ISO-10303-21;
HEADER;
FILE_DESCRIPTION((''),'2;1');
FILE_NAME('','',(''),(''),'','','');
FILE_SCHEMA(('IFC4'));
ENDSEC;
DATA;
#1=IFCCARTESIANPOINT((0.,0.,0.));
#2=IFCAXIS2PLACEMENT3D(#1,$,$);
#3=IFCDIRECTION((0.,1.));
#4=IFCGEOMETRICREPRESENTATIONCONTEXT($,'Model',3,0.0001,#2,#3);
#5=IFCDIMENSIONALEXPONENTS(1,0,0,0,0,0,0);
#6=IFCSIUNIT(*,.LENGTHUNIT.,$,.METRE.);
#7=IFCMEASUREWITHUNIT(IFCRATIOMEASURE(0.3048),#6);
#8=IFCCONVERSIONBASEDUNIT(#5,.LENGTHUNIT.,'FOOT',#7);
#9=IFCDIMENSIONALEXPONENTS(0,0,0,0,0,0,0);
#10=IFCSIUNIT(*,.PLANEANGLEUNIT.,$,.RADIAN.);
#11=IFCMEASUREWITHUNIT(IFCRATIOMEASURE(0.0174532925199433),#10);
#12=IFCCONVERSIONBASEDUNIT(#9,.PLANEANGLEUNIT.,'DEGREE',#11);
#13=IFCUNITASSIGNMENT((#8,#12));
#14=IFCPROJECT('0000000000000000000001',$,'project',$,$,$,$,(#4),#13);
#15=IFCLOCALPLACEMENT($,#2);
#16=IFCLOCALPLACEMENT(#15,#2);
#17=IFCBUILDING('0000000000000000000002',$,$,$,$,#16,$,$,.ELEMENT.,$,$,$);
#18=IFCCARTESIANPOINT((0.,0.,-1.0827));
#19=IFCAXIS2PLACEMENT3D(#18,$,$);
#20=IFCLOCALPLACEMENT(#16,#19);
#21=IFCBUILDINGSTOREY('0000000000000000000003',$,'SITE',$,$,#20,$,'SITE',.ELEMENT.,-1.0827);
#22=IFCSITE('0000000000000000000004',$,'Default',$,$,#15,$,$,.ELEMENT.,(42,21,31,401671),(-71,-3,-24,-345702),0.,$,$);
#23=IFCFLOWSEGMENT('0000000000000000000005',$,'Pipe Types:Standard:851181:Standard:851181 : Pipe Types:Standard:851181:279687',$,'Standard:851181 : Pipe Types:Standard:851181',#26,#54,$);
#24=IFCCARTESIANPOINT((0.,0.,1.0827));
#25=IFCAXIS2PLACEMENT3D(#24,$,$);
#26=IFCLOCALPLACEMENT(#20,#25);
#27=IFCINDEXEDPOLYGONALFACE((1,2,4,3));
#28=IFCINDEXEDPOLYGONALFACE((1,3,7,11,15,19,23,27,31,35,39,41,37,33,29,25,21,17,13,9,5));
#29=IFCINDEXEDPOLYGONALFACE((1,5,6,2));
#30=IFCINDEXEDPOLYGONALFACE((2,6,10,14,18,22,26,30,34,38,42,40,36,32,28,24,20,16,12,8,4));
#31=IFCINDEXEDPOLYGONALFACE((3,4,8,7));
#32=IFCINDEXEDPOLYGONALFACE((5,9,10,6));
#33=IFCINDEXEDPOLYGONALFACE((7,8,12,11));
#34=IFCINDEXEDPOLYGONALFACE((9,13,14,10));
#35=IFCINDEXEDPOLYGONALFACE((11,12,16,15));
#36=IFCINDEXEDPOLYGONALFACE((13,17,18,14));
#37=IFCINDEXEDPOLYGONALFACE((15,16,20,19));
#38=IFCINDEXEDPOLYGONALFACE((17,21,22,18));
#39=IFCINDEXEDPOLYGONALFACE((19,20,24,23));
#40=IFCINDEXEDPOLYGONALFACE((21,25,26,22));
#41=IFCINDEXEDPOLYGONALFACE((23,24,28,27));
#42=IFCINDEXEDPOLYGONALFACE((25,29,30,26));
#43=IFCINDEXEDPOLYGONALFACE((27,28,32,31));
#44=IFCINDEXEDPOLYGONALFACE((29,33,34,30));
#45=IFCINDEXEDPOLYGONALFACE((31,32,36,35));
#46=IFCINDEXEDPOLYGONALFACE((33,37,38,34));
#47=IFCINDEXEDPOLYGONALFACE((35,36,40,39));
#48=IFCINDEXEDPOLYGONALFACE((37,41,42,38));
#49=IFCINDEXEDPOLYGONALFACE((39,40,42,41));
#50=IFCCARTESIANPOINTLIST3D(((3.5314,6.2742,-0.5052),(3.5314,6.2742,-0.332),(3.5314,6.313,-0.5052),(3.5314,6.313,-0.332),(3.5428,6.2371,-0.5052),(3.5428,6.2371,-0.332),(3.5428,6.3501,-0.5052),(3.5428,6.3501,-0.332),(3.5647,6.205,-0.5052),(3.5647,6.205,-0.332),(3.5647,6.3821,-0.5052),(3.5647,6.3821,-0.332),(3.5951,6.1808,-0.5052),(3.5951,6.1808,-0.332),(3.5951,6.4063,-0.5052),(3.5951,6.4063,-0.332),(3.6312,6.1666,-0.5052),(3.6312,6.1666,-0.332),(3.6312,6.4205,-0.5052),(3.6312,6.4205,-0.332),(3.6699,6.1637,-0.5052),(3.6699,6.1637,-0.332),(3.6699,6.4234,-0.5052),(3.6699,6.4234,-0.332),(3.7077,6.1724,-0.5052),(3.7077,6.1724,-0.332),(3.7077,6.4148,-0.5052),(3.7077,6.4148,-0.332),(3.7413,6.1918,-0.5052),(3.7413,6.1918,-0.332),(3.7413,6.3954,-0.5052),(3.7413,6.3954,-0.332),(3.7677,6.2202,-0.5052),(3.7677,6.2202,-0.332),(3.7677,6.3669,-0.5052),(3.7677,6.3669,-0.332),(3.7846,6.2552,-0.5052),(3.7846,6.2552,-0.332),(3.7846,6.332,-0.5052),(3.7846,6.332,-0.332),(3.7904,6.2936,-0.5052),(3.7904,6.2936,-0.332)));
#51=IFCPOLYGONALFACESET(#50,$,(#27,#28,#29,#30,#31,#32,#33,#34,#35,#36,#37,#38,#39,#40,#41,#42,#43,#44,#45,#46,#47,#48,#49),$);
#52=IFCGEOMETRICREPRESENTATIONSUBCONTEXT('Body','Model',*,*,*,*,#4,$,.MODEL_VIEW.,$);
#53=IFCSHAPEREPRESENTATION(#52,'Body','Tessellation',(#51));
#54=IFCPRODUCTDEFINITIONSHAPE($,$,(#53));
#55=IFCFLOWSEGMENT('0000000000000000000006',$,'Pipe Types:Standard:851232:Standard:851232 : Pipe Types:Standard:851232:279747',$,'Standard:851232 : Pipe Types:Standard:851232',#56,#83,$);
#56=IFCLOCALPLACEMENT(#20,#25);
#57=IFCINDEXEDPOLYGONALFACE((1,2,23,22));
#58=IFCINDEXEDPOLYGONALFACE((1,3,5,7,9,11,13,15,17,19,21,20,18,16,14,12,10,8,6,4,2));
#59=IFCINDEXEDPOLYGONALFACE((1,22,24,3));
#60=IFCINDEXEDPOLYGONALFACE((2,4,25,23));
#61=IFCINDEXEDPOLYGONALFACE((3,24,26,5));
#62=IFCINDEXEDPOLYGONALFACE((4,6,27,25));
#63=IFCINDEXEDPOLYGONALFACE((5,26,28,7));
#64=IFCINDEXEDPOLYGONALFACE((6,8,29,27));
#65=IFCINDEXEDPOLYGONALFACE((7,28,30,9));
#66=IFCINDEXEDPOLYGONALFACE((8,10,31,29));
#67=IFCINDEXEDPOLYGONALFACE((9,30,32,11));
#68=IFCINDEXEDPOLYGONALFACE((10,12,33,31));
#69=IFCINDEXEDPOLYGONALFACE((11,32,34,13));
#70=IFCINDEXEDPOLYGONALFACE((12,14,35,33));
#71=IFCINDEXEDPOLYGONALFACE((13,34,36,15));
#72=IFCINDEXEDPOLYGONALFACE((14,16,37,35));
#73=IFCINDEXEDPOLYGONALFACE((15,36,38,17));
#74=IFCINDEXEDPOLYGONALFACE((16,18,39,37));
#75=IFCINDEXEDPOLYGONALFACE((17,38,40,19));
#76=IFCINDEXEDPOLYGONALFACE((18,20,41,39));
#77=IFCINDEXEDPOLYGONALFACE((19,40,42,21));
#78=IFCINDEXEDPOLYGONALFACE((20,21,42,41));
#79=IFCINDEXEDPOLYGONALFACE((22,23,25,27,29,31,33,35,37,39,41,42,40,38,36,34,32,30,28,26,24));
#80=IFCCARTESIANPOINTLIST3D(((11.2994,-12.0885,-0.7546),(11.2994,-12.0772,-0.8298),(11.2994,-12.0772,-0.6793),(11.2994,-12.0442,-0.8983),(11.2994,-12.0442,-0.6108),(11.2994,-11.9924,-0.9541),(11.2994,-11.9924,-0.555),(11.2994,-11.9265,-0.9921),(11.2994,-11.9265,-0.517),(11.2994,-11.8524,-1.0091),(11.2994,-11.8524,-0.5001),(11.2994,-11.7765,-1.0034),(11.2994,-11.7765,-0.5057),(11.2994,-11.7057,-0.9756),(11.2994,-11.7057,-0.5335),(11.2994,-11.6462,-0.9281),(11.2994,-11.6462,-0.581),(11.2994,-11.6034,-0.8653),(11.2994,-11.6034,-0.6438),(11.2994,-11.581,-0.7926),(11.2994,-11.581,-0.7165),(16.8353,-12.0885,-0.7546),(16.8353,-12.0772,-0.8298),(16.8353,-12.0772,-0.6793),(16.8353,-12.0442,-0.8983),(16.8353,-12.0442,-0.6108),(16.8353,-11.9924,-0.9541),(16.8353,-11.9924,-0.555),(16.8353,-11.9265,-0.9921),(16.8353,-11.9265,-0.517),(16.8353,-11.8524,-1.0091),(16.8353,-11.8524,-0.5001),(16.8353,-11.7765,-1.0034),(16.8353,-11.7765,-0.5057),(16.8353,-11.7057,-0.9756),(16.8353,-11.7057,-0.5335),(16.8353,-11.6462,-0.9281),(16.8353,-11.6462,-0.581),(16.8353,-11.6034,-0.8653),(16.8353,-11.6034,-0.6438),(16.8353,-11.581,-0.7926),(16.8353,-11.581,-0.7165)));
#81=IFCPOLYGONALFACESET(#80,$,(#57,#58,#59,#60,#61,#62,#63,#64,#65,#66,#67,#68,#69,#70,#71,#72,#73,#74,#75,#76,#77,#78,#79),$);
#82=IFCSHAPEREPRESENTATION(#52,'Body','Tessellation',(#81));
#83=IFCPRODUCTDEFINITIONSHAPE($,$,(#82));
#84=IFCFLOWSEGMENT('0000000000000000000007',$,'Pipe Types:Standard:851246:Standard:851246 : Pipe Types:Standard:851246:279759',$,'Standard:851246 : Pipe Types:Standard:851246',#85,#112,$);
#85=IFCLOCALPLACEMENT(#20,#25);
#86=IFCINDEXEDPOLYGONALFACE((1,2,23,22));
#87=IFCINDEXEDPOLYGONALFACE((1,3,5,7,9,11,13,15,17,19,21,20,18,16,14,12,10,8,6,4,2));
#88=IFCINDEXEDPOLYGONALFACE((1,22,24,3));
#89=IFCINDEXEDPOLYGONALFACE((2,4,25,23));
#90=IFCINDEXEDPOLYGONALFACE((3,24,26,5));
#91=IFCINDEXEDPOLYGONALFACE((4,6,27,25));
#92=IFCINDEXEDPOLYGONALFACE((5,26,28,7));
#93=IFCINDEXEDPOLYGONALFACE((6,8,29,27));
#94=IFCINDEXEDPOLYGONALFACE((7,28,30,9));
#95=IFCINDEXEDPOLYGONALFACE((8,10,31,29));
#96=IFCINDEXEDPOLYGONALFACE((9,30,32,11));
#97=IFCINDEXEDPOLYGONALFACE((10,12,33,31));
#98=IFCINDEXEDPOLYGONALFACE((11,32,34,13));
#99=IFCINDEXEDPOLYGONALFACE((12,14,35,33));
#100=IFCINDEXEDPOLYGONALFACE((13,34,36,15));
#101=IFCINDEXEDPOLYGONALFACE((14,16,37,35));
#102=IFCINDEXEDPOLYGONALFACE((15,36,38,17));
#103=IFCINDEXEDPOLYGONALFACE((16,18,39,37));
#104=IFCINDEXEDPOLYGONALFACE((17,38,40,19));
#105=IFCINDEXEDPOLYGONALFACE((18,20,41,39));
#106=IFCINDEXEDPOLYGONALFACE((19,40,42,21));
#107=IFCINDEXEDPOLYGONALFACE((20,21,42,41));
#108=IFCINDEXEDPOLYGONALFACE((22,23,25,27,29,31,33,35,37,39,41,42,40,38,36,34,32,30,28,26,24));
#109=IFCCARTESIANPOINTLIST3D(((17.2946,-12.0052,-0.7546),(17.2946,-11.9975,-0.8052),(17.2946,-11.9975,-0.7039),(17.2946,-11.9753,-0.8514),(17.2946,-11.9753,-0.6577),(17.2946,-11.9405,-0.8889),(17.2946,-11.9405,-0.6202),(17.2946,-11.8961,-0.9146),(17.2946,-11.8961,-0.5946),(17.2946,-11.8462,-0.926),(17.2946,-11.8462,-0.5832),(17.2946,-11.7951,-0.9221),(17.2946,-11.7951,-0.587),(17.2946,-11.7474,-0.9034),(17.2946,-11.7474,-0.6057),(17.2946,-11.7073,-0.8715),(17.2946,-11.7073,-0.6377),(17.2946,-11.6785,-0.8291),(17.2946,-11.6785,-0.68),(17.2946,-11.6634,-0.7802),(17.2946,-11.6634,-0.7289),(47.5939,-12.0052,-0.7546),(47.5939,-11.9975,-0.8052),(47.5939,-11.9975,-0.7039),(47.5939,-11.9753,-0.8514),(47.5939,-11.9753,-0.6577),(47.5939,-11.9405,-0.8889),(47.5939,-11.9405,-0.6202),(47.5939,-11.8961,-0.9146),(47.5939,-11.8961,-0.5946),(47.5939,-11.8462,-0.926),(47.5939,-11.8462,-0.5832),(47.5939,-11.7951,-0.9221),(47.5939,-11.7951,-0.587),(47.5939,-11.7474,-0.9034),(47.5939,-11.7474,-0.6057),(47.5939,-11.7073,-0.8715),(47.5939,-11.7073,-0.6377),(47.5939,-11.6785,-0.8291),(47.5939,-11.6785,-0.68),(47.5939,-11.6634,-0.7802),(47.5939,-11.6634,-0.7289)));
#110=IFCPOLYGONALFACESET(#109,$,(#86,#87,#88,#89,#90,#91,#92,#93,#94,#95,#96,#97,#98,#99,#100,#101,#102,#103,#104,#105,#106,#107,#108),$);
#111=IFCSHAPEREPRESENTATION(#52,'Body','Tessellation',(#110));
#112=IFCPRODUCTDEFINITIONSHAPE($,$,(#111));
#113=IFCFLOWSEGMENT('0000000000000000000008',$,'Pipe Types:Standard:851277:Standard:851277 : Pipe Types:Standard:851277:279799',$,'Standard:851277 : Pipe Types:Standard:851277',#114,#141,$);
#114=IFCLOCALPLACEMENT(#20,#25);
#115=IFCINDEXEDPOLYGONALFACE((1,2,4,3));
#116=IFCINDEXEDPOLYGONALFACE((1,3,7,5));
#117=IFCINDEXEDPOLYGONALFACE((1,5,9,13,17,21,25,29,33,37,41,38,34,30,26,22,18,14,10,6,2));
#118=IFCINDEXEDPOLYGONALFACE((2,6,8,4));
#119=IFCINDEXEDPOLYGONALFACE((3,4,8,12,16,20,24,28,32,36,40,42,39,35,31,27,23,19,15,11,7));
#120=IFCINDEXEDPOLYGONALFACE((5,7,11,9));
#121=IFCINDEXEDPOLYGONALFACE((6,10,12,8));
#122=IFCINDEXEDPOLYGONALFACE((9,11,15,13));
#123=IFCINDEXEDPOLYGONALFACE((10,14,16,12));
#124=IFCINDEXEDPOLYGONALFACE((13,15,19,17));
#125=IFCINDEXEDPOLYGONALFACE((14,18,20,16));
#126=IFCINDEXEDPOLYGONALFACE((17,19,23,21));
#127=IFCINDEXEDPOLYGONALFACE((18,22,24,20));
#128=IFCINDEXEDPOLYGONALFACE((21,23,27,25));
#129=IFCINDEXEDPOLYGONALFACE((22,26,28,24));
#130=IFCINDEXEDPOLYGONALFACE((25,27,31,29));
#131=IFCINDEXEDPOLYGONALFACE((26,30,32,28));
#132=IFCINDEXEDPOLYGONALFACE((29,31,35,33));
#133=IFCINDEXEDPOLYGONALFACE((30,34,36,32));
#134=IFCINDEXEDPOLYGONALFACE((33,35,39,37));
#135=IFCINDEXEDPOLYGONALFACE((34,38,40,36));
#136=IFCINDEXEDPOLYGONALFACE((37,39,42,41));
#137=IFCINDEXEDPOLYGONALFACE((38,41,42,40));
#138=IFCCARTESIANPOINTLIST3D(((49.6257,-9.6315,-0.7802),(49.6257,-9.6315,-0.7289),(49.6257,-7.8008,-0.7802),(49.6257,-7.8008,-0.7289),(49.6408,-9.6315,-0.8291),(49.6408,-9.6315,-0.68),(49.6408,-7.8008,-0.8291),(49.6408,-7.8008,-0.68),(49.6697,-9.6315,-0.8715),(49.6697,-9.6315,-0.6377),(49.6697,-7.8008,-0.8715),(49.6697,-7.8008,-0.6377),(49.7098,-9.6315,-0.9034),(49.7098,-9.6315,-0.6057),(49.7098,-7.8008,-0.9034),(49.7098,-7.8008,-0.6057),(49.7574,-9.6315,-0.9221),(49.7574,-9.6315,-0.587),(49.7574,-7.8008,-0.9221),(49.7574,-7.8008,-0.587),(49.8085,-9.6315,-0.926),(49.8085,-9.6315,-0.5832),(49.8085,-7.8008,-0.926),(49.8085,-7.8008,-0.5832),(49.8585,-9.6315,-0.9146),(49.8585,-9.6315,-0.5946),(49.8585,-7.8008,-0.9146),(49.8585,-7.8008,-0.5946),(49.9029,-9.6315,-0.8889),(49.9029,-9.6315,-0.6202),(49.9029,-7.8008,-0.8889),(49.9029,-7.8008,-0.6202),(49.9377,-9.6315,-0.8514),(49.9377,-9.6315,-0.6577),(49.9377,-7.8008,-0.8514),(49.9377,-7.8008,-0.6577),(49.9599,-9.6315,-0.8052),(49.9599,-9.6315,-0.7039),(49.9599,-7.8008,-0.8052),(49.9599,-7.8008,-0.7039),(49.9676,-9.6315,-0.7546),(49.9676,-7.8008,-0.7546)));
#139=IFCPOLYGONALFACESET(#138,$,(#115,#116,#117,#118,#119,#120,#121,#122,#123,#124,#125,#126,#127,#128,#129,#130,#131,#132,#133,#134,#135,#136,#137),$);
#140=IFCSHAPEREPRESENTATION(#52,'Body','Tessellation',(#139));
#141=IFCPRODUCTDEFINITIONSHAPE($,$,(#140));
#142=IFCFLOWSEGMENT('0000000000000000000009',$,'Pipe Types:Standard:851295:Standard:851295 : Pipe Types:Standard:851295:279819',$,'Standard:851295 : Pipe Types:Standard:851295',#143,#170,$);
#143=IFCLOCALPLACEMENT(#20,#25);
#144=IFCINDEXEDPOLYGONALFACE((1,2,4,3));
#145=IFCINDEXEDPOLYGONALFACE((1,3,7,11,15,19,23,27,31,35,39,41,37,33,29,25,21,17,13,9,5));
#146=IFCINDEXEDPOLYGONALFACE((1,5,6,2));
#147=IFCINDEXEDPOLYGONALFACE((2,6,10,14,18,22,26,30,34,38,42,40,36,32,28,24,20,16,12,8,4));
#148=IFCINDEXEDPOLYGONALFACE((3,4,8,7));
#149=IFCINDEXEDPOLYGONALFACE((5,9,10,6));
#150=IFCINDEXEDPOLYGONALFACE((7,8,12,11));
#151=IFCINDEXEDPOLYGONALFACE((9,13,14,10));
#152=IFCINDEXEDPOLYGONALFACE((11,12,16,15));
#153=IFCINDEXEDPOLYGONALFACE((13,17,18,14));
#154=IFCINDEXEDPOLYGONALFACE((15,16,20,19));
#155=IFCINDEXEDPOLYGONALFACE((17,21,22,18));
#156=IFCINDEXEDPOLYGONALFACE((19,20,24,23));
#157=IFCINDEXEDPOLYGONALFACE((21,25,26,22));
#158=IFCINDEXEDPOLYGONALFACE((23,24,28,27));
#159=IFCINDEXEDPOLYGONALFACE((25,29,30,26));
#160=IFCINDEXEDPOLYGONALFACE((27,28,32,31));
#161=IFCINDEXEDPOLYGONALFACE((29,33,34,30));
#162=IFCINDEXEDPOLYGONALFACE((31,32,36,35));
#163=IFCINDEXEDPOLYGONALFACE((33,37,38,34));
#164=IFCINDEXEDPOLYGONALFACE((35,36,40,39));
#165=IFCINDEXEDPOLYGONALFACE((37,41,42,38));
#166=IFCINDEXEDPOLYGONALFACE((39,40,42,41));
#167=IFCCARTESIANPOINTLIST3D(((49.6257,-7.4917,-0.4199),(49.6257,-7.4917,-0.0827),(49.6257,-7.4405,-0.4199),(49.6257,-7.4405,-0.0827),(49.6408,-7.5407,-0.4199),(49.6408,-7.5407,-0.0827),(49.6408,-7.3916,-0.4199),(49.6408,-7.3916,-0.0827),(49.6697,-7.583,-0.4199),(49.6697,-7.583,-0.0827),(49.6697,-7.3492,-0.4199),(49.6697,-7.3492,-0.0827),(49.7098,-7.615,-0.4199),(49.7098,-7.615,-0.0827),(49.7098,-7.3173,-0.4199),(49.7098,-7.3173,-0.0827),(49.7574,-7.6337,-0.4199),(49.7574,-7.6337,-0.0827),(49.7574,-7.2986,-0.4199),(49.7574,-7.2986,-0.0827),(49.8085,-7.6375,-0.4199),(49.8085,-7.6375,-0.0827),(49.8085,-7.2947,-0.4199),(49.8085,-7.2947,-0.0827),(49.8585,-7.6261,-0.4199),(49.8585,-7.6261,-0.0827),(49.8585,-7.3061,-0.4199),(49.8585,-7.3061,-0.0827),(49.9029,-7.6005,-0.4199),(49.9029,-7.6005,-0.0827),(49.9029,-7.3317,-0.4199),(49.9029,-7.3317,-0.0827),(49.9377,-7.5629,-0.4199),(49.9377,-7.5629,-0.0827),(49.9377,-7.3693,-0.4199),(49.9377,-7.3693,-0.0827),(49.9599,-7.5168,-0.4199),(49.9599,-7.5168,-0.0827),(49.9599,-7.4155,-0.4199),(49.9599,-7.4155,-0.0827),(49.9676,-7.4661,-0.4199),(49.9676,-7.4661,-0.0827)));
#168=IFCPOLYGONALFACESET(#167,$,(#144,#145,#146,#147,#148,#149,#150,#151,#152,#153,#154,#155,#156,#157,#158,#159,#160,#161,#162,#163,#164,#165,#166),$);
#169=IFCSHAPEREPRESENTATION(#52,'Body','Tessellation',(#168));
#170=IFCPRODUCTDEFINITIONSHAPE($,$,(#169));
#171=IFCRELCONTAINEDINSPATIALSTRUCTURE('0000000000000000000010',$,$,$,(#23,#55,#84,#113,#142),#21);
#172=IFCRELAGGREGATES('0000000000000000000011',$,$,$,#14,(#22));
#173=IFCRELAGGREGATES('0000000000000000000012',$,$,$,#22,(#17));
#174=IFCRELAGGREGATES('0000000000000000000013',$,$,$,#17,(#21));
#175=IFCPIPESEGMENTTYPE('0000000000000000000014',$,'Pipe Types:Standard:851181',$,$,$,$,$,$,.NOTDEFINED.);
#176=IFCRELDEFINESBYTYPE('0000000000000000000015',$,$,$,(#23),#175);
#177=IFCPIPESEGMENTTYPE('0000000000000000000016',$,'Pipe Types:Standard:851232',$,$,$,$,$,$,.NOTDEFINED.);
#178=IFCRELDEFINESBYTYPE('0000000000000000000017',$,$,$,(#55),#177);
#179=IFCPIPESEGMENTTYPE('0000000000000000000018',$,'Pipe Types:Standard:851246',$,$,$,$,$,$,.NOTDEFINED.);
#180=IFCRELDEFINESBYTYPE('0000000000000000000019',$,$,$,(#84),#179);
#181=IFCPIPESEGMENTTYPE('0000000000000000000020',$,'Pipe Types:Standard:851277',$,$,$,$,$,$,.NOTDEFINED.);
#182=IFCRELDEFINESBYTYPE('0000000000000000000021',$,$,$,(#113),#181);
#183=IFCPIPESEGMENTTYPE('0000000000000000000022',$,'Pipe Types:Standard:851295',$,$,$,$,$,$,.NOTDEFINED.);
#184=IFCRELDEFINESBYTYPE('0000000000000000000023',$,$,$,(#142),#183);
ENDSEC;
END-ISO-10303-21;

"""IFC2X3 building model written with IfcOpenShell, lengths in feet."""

from ifc_helpers import new_model, entity, si_unit, converted_unit, direction, frame, frame_2d, origin, origin_2d_with_axis, place, context, subcontext, project, spatial, circle, extrude, source, transform, mapped, type_object, type_shapes, element, save


model = new_model("IFC2X3")

# Units and contexts
model_context = context("Model", 3, precision=0.0001, world=origin(), true_north=direction((0.0, 1.0)))
body_context = subcontext(model_context, "Body", "Model", "MODEL_VIEW")
ifc_project = project(units=[converted_unit("LENGTHUNIT", "FOOT", entity("IfcRatioMeasure", 0.3048), si_unit("LENGTHUNIT", "METRE"), dimensions=[1, 0, 0, 0, 0, 0, 0]), converted_unit("PLANEANGLEUNIT", "DEGREE", entity("IfcRatioMeasure", 0.0174532925199433), si_unit("PLANEANGLEUNIT", "RADIAN"), dimensions=[0, 0, 0, 0, 0, 0, 0])], contexts=[model_context])

# Site, building, storey
site_placement = place(None, origin())
site = spatial("IfcSite", under=ifc_project, at=site_placement, Name="Default", CompositionType="ELEMENT", RefLatitude=(42, 21, 31, 401671), RefLongitude=(-71, -3, -24, -345702), RefElevation=0.0)
building_placement = place(site_placement, origin())
building = spatial("IfcBuilding", under=site, at=building_placement, CompositionType="ELEMENT")
storey_placement = place(building_placement, frame((0.0, 0.0, -1.0827)))
storey = spatial("IfcBuildingStorey", under=building, at=storey_placement, Name="SITE", LongName="SITE", CompositionType="ELEMENT", Elevation=-1.0827)

# Flow segments
pipe_segment_type_1 = type_object("IfcPipeSegmentType", Name="Pipe Types:Standard:851181", PredefinedType="NOTDEFINED")
shared_shape_1 = source(origin(), body_context, "Body", "SweptSolid", [
    extrude(circle(Radius=0.1302, at=origin_2d_with_axis()), frame((3.6602, 6.2936, -0.5052)), (0.0, 0.0, 1.0), 0.1732),
])
type_shapes(pipe_segment_type_1, [shared_shape_1])
flow_segment_1_placement = place(storey_placement, frame((0.0, 0.0, 1.0827)))
element("IfcFlowSegment", 1, at=flow_segment_1_placement, inside=storey, type_object=pipe_segment_type_1, Name="Pipe Types:Standard:851181:Standard:851181 : Pipe Types:Standard:851181:279687", ObjectType="Standard:851181 : Pipe Types:Standard:851181", context=body_context, shape_type="MappedRepresentation", body=[
    mapped(shared_shape_1, transform((0.0, 0.0, 0.0), scale=1.0)),
])
pipe_segment_type_2 = type_object("IfcPipeSegmentType", Name="Pipe Types:Standard:851232", PredefinedType="NOTDEFINED")
shared_shape_2 = source(origin(), body_context, "Body", "SweptSolid", [
    extrude(circle(Radius=0.2552, at=frame_2d((0.0, 0.0), x_axis=(1.0, 0.0))), frame((11.2994, -11.8333, -0.7546), z_axis=(1.0, 0.0, 0.0), x_axis=(0.0, -1.0, 0.0)), (0.0, 0.0, 1.0), 5.5359),
])
type_shapes(pipe_segment_type_2, [shared_shape_2])
flow_segment_2_placement = place(storey_placement, frame((0.0, 0.0, 1.0827)))
element("IfcFlowSegment", 2, at=flow_segment_2_placement, inside=storey, type_object=pipe_segment_type_2, Name="Pipe Types:Standard:851232:Standard:851232 : Pipe Types:Standard:851232:279747", ObjectType="Standard:851232 : Pipe Types:Standard:851232", context=body_context, shape_type="MappedRepresentation", body=[
    mapped(shared_shape_2, transform((0.0, 0.0, 0.0), scale=1.0)),
])
pipe_segment_type_3 = type_object("IfcPipeSegmentType", Name="Pipe Types:Standard:851246", PredefinedType="NOTDEFINED")
shared_shape_3 = source(origin(), body_context, "Body", "SweptSolid", [
    extrude(circle(Radius=0.1719, at=frame_2d((0.0, 0.0), x_axis=(1.0, 0.0))), frame((17.2946, -11.8333, -0.7546), z_axis=(1.0, 0.0, 0.0), x_axis=(0.0, -1.0, 0.0)), (0.0, 0.0, 1.0), 30.2992),
])
type_shapes(pipe_segment_type_3, [shared_shape_3])
flow_segment_3_placement = place(storey_placement, frame((0.0, 0.0, 1.0827)))
element("IfcFlowSegment", 3, at=flow_segment_3_placement, inside=storey, type_object=pipe_segment_type_3, Name="Pipe Types:Standard:851246:Standard:851246 : Pipe Types:Standard:851246:279759", ObjectType="Standard:851246 : Pipe Types:Standard:851246", context=body_context, shape_type="MappedRepresentation", body=[
    mapped(shared_shape_3, transform((0.0, 0.0, 0.0), scale=1.0)),
])
pipe_segment_type_4 = type_object("IfcPipeSegmentType", Name="Pipe Types:Standard:851277", PredefinedType="NOTDEFINED")
shared_shape_4 = source(origin(), body_context, "Body", "SweptSolid", [
    extrude(circle(Radius=0.1719, at=frame_2d((0.0, 0.0), x_axis=(1.0, 0.0))), frame((49.7957, -9.6315, -0.7546), z_axis=(0.0, 1.0, 0.0), x_axis=(1.0, 0.0, 0.0)), (0.0, 0.0, 1.0), 1.8307),
])
type_shapes(pipe_segment_type_4, [shared_shape_4])
flow_segment_4_placement = place(storey_placement, frame((0.0, 0.0, 1.0827)))
element("IfcFlowSegment", 4, at=flow_segment_4_placement, inside=storey, type_object=pipe_segment_type_4, Name="Pipe Types:Standard:851277:Standard:851277 : Pipe Types:Standard:851277:279799", ObjectType="Standard:851277 : Pipe Types:Standard:851277", context=body_context, shape_type="MappedRepresentation", body=[
    mapped(shared_shape_4, transform((0.0, 0.0, 0.0), scale=1.0)),
])
pipe_segment_type_5 = type_object("IfcPipeSegmentType", Name="Pipe Types:Standard:851295", PredefinedType="NOTDEFINED")
shared_shape_5 = source(origin(), body_context, "Body", "SweptSolid", [
    extrude(circle(Radius=0.1719, at=frame_2d((0.0, 0.0), x_axis=(1.0, 0.0))), frame((49.7957, -7.4661, -0.4199)), (0.0, 0.0, 1.0), 0.3372),
])
type_shapes(pipe_segment_type_5, [shared_shape_5])
flow_segment_5_placement = place(storey_placement, frame((0.0, 0.0, 1.0827)))
element("IfcFlowSegment", 5, at=flow_segment_5_placement, inside=storey, type_object=pipe_segment_type_5, Name="Pipe Types:Standard:851295:Standard:851295 : Pipe Types:Standard:851295:279819", ObjectType="Standard:851295 : Pipe Types:Standard:851295", context=body_context, shape_type="MappedRepresentation", body=[
    mapped(shared_shape_5, transform((0.0, 0.0, 0.0), scale=1.0)),
])

save(model, "model.ifc")
